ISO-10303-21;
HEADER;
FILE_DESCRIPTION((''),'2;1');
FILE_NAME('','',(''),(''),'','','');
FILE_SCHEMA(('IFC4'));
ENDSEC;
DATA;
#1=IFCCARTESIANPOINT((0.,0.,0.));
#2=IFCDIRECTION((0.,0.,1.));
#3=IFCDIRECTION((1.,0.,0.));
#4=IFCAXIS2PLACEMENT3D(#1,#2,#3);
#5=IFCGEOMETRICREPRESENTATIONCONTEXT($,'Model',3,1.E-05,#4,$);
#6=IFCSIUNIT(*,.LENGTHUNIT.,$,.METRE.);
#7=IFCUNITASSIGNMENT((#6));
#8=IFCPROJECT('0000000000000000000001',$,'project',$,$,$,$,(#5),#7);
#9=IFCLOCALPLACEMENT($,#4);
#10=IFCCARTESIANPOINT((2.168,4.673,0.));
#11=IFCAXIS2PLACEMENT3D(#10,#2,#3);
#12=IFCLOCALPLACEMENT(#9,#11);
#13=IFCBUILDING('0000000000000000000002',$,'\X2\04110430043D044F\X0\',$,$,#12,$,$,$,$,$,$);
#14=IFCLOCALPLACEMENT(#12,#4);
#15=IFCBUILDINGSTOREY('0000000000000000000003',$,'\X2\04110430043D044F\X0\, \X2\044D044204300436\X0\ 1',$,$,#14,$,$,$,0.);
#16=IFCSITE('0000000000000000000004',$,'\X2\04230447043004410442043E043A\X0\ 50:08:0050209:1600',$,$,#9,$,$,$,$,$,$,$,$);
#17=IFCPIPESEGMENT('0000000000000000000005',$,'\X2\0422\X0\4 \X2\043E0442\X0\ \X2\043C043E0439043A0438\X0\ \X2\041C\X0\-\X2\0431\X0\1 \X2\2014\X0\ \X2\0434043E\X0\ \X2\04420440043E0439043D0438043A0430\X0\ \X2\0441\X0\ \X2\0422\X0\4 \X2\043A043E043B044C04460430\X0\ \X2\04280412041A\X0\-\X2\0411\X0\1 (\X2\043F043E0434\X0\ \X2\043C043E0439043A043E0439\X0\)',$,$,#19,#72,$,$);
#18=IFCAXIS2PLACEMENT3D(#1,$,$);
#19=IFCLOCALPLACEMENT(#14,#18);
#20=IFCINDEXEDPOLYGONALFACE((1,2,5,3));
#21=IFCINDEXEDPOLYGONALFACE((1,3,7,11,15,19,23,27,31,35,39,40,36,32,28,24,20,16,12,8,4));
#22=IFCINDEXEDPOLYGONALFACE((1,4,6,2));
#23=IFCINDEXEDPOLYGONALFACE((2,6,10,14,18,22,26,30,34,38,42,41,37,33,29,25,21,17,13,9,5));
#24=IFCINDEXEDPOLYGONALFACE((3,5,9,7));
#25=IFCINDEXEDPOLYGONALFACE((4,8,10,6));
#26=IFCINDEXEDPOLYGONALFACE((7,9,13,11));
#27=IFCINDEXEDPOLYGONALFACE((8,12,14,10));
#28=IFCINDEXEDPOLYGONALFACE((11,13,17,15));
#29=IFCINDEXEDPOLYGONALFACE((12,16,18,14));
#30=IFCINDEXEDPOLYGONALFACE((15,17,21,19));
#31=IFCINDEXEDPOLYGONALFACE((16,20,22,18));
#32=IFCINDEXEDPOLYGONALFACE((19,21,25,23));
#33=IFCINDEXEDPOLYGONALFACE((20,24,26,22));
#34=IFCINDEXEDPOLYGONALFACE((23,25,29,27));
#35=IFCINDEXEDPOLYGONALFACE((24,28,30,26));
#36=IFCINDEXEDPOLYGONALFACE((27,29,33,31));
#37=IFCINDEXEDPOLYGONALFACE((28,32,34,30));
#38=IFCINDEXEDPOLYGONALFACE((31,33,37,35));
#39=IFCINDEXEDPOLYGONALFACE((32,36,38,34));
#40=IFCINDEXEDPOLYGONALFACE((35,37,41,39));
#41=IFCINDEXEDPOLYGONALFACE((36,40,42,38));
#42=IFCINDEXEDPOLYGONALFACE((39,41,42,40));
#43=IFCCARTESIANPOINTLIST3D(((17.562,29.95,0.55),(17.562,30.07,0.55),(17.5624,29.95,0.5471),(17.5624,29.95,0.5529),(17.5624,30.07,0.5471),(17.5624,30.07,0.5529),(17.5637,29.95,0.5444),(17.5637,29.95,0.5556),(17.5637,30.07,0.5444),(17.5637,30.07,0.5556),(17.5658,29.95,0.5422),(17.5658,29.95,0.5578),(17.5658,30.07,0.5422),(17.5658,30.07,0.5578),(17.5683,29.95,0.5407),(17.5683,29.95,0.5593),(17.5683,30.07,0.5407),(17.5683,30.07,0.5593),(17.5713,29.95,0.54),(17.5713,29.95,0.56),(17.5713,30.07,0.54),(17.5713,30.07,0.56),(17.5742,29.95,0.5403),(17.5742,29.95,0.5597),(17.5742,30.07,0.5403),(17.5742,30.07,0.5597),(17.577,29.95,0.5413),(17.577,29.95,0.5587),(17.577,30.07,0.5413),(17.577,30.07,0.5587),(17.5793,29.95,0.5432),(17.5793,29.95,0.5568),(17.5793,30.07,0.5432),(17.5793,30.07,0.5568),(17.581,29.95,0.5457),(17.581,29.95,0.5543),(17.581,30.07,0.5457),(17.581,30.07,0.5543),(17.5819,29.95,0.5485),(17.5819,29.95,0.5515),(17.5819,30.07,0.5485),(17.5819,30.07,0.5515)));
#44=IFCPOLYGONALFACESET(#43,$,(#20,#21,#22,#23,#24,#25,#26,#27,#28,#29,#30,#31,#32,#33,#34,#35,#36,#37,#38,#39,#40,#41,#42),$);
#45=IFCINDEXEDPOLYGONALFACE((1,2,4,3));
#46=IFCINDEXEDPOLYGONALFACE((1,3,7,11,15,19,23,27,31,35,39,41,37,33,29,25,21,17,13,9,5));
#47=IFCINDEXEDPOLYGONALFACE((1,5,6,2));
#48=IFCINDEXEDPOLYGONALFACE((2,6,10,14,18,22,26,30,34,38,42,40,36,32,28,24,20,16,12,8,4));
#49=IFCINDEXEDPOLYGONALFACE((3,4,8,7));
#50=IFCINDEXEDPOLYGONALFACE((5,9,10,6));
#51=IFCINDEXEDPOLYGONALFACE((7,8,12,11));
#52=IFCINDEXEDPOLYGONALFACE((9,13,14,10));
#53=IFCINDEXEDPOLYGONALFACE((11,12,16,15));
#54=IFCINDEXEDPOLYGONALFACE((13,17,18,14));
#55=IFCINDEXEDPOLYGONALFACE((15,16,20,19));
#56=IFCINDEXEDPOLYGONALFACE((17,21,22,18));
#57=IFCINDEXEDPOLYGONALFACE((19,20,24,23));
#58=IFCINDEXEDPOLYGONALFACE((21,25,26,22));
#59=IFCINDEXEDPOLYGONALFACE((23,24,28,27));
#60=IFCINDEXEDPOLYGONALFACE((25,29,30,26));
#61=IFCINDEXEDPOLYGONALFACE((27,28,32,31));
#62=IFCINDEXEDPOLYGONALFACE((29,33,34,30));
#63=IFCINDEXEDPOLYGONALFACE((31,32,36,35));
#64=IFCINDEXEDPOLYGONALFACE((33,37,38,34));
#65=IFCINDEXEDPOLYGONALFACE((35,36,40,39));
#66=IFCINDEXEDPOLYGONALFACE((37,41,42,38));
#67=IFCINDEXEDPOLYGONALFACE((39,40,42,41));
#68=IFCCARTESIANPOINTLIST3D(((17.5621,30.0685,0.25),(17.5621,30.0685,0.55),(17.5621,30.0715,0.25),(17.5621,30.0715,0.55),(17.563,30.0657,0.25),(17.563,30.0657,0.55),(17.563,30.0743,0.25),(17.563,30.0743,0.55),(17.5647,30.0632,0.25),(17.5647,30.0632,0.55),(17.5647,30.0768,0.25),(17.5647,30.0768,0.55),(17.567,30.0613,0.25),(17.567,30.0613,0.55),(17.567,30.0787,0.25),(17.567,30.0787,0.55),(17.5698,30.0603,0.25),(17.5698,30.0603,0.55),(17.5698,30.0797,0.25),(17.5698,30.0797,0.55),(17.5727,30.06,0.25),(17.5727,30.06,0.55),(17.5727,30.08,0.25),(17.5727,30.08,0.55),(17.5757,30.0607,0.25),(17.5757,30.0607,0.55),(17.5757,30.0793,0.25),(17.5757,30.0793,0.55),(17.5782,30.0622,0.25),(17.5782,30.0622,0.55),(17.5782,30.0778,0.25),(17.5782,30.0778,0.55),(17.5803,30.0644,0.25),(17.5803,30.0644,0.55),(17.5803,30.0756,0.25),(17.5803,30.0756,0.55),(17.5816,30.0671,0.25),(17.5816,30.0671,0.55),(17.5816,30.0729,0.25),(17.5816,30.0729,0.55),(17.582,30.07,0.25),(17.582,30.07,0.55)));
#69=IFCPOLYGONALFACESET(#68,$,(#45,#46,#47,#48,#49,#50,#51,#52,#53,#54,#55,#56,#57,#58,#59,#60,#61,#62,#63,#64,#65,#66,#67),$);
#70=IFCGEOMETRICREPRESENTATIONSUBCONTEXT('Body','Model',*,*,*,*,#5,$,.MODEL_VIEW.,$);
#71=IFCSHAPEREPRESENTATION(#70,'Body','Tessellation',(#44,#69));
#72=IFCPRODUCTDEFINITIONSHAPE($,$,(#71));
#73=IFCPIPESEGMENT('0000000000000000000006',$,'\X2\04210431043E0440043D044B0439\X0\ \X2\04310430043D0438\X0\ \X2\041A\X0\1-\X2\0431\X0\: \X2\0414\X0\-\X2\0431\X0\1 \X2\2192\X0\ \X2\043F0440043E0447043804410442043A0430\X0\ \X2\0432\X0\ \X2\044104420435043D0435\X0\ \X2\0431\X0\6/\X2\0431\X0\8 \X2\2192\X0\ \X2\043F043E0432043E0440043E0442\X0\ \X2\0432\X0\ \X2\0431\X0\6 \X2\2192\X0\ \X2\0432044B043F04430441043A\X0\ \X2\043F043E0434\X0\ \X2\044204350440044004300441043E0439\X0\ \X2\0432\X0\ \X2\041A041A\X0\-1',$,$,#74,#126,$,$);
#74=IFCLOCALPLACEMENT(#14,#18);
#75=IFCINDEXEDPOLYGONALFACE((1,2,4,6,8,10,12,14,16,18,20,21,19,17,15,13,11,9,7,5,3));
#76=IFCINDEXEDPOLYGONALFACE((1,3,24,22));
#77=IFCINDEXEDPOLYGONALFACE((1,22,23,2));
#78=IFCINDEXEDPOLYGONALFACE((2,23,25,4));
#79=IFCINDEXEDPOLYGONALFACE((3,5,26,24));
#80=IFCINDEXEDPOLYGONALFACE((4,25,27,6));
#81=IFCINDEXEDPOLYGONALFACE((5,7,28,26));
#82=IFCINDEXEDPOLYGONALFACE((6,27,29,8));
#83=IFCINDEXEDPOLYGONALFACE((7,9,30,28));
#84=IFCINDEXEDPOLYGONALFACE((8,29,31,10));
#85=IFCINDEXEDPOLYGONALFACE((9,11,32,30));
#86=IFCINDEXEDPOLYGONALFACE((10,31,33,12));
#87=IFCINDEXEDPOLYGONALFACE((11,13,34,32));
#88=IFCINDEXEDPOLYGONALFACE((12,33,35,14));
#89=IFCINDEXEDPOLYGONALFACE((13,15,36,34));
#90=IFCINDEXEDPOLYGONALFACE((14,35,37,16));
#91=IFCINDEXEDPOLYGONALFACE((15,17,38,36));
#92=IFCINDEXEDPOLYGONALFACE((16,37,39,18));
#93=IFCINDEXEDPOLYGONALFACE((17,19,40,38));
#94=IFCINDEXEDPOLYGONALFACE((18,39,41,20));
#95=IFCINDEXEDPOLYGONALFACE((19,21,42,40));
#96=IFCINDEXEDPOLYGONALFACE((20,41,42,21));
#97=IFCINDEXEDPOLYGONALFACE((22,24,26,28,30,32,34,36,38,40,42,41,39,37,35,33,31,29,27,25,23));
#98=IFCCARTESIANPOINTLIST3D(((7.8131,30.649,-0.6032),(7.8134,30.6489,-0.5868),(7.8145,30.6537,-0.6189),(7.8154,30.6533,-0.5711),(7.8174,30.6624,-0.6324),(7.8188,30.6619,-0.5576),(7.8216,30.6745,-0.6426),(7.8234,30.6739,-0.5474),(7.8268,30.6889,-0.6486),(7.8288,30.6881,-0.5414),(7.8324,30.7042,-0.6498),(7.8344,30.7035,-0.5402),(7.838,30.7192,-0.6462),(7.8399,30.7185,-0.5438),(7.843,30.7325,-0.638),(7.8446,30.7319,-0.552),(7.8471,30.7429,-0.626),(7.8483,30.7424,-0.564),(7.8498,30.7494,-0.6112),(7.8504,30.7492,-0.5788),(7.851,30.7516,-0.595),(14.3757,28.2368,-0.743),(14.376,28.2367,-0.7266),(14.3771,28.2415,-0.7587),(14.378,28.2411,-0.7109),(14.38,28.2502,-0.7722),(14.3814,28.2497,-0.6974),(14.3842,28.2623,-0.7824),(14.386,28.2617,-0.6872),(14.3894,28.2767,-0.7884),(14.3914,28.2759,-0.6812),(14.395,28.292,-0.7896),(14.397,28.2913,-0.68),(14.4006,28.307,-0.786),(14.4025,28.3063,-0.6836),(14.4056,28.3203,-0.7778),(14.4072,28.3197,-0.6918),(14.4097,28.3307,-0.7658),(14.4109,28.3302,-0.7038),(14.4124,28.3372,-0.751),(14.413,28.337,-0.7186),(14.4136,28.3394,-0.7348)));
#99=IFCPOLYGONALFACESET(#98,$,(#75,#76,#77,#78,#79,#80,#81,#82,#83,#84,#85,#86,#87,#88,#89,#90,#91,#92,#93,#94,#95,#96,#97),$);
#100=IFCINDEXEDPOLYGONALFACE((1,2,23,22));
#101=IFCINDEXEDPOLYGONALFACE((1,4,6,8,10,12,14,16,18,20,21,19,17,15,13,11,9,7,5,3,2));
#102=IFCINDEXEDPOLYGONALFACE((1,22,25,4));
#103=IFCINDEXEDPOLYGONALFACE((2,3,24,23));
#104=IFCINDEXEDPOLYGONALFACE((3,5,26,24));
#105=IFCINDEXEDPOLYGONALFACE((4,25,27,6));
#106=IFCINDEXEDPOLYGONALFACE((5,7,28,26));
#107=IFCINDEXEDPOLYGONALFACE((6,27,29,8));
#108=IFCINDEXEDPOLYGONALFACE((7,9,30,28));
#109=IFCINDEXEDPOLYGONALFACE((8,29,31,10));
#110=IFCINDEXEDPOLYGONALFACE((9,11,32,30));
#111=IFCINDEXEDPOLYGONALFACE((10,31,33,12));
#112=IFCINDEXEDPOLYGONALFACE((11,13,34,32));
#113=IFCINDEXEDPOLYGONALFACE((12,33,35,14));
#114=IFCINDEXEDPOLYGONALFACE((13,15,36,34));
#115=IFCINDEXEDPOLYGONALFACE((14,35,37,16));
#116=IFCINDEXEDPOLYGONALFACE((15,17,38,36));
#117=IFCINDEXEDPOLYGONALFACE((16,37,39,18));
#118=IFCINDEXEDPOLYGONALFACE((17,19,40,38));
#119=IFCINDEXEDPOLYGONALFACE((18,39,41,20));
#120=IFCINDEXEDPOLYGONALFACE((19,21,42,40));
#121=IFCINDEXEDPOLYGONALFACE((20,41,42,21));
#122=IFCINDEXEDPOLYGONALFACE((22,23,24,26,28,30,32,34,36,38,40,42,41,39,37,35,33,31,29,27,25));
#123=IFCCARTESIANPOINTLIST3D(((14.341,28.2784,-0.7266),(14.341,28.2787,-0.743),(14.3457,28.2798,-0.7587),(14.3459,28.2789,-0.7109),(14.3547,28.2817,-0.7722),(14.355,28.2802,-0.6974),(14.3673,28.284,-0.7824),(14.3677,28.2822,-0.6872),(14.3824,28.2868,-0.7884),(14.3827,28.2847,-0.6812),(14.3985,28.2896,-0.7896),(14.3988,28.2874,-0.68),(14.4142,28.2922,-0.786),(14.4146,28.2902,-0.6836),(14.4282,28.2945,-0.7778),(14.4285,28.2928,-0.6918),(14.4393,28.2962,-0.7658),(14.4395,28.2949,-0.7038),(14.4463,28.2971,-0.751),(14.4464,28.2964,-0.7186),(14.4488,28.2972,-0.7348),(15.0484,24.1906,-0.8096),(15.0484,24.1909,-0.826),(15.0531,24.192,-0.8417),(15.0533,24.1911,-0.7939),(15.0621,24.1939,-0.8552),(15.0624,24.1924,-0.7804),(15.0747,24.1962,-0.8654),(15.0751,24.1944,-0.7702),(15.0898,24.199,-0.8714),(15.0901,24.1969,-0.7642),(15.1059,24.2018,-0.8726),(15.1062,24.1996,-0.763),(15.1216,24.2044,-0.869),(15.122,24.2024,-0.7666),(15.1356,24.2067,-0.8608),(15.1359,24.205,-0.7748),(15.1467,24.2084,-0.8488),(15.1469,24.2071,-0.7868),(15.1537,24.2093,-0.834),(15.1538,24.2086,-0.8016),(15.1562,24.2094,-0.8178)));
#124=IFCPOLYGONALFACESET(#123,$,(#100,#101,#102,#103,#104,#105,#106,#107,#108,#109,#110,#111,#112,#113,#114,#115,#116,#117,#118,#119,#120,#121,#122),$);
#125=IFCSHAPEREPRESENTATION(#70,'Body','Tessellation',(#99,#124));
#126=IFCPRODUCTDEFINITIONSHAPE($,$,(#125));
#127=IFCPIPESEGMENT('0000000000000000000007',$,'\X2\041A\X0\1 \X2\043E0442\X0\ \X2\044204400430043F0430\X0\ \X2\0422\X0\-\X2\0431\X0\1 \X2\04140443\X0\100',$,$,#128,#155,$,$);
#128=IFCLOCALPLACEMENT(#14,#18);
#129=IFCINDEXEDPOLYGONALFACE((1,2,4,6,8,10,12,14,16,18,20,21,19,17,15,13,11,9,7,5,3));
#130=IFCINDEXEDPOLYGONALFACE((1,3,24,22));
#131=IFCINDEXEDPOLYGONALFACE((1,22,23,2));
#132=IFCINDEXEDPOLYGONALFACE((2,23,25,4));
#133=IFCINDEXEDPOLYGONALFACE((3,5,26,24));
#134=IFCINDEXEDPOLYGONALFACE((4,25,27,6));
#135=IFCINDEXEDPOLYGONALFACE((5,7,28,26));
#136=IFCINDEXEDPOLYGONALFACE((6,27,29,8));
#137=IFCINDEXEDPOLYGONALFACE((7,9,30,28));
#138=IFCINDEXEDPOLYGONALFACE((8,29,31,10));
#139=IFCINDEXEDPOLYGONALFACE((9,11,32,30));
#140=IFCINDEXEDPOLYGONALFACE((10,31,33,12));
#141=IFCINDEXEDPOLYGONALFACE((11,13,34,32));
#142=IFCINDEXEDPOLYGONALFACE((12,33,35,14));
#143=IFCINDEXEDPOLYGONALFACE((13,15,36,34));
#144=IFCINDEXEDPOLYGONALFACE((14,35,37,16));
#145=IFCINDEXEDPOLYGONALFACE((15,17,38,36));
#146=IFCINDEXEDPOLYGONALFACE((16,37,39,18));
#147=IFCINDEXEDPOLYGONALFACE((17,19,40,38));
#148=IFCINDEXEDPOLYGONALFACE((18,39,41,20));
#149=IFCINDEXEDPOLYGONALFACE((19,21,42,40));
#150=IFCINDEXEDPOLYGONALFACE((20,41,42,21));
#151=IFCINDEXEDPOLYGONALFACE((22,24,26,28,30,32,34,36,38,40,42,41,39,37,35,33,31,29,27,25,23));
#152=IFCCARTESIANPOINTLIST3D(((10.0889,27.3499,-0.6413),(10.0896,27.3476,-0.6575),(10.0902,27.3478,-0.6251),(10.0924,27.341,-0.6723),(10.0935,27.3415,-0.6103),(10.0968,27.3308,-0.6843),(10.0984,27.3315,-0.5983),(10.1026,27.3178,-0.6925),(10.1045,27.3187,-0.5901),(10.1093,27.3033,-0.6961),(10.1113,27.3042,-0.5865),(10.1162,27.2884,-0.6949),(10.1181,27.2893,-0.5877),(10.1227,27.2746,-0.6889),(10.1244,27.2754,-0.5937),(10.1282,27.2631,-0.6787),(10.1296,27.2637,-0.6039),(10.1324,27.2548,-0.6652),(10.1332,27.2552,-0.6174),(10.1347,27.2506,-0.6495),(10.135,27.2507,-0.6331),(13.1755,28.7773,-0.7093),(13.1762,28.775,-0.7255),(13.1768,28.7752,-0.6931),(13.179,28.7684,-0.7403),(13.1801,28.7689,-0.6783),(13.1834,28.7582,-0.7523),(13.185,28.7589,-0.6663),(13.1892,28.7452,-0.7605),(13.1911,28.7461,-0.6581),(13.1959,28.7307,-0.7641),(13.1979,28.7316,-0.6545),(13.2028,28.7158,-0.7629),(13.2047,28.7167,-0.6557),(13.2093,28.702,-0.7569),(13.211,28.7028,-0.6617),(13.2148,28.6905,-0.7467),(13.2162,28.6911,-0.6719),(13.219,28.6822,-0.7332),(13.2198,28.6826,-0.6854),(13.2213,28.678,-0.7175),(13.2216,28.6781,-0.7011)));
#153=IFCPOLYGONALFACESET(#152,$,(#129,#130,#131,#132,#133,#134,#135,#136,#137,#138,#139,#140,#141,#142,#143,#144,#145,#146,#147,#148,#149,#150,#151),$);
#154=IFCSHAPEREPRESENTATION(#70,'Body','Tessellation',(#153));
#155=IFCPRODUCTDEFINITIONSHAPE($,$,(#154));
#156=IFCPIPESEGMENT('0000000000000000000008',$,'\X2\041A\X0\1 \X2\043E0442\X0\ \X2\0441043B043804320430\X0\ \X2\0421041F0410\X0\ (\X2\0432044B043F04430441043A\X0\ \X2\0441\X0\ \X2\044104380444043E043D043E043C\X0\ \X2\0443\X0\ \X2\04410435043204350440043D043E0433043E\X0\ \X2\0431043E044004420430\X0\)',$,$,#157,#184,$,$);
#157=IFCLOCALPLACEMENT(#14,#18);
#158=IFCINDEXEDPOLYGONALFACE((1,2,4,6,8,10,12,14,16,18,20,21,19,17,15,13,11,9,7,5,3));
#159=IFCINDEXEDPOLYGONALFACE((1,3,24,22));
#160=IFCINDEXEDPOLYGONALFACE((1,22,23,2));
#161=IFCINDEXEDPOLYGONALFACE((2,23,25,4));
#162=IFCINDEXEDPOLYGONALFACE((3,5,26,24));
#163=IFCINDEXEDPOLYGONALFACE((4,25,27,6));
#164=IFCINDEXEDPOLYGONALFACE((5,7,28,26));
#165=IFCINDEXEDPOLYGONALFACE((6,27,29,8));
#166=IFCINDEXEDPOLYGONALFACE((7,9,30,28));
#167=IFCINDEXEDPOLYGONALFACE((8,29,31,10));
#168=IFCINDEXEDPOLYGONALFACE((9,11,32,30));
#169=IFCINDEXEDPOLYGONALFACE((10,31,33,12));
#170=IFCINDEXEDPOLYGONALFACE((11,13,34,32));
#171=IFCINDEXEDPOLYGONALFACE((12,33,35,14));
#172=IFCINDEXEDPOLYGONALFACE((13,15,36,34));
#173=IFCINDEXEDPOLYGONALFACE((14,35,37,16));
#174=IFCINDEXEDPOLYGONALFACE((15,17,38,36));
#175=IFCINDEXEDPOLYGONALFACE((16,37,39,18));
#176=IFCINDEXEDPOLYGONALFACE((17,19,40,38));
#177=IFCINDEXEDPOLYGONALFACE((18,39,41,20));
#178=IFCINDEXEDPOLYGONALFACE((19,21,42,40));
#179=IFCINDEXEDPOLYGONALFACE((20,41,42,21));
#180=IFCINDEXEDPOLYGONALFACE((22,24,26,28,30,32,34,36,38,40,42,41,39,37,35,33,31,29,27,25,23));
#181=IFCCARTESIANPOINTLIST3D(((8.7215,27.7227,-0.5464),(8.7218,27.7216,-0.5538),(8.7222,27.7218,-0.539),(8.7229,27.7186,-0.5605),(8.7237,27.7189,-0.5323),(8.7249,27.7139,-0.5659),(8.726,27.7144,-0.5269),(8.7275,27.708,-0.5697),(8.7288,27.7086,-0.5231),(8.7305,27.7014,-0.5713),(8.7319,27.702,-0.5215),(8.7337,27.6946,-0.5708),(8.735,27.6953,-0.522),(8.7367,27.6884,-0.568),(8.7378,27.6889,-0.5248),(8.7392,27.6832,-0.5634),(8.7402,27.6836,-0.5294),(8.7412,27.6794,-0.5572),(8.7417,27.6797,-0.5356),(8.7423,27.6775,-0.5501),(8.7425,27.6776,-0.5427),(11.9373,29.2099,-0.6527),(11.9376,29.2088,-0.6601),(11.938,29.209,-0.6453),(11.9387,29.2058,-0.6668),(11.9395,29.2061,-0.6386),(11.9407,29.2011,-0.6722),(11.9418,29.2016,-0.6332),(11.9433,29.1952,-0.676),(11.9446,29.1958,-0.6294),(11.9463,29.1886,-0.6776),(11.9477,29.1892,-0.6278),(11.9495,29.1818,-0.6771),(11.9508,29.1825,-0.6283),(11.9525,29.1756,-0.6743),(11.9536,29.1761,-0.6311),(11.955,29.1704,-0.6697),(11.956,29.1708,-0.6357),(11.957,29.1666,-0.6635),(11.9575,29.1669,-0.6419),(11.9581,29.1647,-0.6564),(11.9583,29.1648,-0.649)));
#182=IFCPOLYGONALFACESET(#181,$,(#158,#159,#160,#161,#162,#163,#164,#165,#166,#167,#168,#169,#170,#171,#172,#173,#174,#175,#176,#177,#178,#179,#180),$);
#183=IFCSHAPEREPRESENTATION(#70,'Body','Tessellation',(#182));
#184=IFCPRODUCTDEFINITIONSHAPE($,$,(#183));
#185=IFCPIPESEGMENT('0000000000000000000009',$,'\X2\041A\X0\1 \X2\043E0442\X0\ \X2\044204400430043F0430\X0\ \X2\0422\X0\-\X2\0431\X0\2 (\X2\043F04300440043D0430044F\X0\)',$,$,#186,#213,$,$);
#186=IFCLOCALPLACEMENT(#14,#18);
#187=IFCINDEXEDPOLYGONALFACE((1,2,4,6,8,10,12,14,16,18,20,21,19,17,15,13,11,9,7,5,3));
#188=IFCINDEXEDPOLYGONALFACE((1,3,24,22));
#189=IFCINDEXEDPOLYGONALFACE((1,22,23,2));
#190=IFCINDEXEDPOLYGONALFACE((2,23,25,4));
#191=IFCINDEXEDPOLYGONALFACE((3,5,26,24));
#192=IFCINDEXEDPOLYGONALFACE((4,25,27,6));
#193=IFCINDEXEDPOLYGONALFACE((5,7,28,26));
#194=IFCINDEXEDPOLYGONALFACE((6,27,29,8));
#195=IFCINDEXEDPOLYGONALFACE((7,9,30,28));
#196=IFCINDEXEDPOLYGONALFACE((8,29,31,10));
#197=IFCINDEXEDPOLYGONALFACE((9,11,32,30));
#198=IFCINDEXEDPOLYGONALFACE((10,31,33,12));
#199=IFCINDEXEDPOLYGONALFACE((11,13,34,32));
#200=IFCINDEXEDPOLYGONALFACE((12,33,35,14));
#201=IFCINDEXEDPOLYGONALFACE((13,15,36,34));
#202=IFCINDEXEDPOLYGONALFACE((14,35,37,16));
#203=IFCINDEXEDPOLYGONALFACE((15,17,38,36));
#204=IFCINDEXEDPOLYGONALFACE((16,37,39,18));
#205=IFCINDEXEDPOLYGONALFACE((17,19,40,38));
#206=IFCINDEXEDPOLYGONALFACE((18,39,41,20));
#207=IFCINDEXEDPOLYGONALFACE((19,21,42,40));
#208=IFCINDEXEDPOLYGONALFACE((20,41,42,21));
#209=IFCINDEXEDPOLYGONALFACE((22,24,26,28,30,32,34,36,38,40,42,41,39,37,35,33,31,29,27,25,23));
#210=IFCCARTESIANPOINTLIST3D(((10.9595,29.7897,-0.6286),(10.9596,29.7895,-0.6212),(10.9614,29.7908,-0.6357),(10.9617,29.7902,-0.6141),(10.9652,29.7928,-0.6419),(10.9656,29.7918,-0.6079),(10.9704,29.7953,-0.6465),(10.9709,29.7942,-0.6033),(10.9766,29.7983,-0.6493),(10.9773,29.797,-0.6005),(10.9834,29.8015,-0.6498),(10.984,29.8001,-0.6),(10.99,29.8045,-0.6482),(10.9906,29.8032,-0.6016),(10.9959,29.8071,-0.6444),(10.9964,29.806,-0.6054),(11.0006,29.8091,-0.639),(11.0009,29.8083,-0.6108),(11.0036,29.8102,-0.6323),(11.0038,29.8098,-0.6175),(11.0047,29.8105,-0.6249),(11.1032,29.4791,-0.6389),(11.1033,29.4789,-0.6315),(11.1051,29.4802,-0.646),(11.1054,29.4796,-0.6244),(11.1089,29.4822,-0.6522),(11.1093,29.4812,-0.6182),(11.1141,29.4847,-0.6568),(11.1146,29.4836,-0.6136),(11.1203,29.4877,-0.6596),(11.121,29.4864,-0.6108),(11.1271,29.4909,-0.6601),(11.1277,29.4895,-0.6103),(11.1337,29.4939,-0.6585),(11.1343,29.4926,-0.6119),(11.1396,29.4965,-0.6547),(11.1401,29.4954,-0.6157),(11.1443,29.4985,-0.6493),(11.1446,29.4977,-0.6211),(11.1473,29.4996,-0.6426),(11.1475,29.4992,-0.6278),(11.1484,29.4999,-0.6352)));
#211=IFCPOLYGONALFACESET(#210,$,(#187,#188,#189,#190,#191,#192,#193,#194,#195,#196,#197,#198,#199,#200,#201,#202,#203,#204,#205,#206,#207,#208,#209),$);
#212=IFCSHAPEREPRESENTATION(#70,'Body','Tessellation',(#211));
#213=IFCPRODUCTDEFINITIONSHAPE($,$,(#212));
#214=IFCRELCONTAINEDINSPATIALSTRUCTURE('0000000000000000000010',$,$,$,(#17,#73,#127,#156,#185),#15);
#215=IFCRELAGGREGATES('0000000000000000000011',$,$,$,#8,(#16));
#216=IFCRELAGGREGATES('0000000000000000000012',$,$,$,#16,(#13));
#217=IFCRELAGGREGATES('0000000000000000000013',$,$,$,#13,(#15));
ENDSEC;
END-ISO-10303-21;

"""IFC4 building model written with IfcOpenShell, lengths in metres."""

from ifc_helpers import new_model, si_unit, frame, origin_with_axes, origin_2d, place, context, subcontext, project, spatial, circle, extrude, element, save


model = new_model("IFC4")

# Units and contexts
model_context = context("Model", 3, precision=1e-05, world=origin_with_axes())
body_context = subcontext(model_context, "Body", "Model", "MODEL_VIEW")
ifc_project = project(units=[si_unit("LENGTHUNIT", "METRE")], contexts=[model_context])

# Site, building, storey
site_placement = place(None, origin_with_axes())
site = spatial("IfcSite", under=ifc_project, at=site_placement, Name="Участок 50:08:0050209:1600")
building_placement = place(site_placement, frame((2.168, 4.673, 0.0), z_axis=(0.0, 0.0, 1.0), x_axis=(1.0, 0.0, 0.0)))
building = spatial("IfcBuilding", under=site, at=building_placement, Name="Баня")
storey_placement = place(building_placement, origin_with_axes())
storey = spatial("IfcBuildingStorey", under=building, at=storey_placement, Name="Баня, этаж 1", Elevation=0.0)

# Pipe segments
pipe_segment_1_placement = place(storey_placement, origin_with_axes())
element("IfcPipeSegment", 1, at=pipe_segment_1_placement, inside=storey, Name="Т4 от мойки М-б1 — до тройника с Т4 кольца ШВК-Б1 (под мойкой)", context=body_context, shape_type="SweptSolid", body=[
    extrude(circle(Radius=0.01, at=origin_2d()), frame((17.572, 29.95, 0.55), z_axis=(0.0, 1.0, 0.0), x_axis=(-1.0, 0.0, 0.0)), (0.0, 0.0, 1.0), 0.12),
    extrude(circle(Radius=0.01, at=origin_2d()), frame((17.572, 30.07, 0.55), z_axis=(0.0, 0.0, -1.0), x_axis=(1.0, 0.0, 0.0)), (0.0, 0.0, 1.0), 0.3),
])
pipe_segment_2_placement = place(storey_placement, origin_with_axes())
element("IfcPipeSegment", 2, at=pipe_segment_2_placement, inside=storey, Name="Сборный бани К1-б: Д-б1 → прочистка в стене б6/б8 → поворот в б6 → выпуск под террасой в КК-1", context=body_context, shape_type="SweptSolid", body=[
    extrude(circle(Radius=0.055, at=origin_2d()), frame((7.832, 30.7, -0.595), z_axis=(0.938415, -0.344931, -0.019991), x_axis=(0.345, 0.938603, 0.0)), (0.0, 0.0, 1.0), 6.9933),
    extrude(circle(Radius=0.055, at=origin_2d()), frame((14.3946, 28.2878, -0.7348), z_axis=(0.170483, -0.985158, -0.020003), x_axis=(0.985355, 0.170517, 0.0)), (0.0, 0.0, 1.0), 4.1494),
])
pipe_segment_3_placement = place(storey_placement, origin_with_axes())
element("IfcPipeSegment", 3, at=pipe_segment_3_placement, inside=storey, Name="К1 от трапа Т-б1 Ду100", context=body_context, shape_type="SweptSolid", body=[
    extrude(circle(Radius=0.055, at=origin_2d()), frame((10.112, 27.3, -0.6413), z_axis=(0.907463, 0.419657, -0.019992), x_axis=(-0.419741, 0.907644, 0.0)), (0.0, 0.0, 1.0), 3.4014),
])
pipe_segment_4_placement = place(storey_placement, origin_with_axes())
element("IfcPipeSegment", 4, at=pipe_segment_4_placement, inside=storey, Name="К1 от слива СПА (выпуск с сифоном у северного борта)", context=body_context, shape_type="SweptSolid", body=[
    extrude(circle(Radius=0.025, at=origin_2d()), frame((8.732, 27.7, -0.5464), z_axis=(0.90723, 0.419564, -0.029989), x_axis=(-0.419753, 0.907639, 0.0)), (0.0, 0.0, 1.0), 3.5446),
])
pipe_segment_5_placement = place(storey_placement, origin_with_axes())
element("IfcPipeSegment", 5, at=pipe_segment_5_placement, inside=storey, Name="К1 от трапа Т-б2 (парная)", context=body_context, shape_type="SweptSolid", body=[
    extrude(circle(Radius=0.025, at=origin_2d()), frame((10.982, 29.8, -0.6249), z_axis=(0.419702, -0.907163, -0.030083), x_axis=(0.907574, 0.419892, 0.0)), (0.0, 0.0, 1.0), 0.3424),
])

save(model, "model.ifc")
